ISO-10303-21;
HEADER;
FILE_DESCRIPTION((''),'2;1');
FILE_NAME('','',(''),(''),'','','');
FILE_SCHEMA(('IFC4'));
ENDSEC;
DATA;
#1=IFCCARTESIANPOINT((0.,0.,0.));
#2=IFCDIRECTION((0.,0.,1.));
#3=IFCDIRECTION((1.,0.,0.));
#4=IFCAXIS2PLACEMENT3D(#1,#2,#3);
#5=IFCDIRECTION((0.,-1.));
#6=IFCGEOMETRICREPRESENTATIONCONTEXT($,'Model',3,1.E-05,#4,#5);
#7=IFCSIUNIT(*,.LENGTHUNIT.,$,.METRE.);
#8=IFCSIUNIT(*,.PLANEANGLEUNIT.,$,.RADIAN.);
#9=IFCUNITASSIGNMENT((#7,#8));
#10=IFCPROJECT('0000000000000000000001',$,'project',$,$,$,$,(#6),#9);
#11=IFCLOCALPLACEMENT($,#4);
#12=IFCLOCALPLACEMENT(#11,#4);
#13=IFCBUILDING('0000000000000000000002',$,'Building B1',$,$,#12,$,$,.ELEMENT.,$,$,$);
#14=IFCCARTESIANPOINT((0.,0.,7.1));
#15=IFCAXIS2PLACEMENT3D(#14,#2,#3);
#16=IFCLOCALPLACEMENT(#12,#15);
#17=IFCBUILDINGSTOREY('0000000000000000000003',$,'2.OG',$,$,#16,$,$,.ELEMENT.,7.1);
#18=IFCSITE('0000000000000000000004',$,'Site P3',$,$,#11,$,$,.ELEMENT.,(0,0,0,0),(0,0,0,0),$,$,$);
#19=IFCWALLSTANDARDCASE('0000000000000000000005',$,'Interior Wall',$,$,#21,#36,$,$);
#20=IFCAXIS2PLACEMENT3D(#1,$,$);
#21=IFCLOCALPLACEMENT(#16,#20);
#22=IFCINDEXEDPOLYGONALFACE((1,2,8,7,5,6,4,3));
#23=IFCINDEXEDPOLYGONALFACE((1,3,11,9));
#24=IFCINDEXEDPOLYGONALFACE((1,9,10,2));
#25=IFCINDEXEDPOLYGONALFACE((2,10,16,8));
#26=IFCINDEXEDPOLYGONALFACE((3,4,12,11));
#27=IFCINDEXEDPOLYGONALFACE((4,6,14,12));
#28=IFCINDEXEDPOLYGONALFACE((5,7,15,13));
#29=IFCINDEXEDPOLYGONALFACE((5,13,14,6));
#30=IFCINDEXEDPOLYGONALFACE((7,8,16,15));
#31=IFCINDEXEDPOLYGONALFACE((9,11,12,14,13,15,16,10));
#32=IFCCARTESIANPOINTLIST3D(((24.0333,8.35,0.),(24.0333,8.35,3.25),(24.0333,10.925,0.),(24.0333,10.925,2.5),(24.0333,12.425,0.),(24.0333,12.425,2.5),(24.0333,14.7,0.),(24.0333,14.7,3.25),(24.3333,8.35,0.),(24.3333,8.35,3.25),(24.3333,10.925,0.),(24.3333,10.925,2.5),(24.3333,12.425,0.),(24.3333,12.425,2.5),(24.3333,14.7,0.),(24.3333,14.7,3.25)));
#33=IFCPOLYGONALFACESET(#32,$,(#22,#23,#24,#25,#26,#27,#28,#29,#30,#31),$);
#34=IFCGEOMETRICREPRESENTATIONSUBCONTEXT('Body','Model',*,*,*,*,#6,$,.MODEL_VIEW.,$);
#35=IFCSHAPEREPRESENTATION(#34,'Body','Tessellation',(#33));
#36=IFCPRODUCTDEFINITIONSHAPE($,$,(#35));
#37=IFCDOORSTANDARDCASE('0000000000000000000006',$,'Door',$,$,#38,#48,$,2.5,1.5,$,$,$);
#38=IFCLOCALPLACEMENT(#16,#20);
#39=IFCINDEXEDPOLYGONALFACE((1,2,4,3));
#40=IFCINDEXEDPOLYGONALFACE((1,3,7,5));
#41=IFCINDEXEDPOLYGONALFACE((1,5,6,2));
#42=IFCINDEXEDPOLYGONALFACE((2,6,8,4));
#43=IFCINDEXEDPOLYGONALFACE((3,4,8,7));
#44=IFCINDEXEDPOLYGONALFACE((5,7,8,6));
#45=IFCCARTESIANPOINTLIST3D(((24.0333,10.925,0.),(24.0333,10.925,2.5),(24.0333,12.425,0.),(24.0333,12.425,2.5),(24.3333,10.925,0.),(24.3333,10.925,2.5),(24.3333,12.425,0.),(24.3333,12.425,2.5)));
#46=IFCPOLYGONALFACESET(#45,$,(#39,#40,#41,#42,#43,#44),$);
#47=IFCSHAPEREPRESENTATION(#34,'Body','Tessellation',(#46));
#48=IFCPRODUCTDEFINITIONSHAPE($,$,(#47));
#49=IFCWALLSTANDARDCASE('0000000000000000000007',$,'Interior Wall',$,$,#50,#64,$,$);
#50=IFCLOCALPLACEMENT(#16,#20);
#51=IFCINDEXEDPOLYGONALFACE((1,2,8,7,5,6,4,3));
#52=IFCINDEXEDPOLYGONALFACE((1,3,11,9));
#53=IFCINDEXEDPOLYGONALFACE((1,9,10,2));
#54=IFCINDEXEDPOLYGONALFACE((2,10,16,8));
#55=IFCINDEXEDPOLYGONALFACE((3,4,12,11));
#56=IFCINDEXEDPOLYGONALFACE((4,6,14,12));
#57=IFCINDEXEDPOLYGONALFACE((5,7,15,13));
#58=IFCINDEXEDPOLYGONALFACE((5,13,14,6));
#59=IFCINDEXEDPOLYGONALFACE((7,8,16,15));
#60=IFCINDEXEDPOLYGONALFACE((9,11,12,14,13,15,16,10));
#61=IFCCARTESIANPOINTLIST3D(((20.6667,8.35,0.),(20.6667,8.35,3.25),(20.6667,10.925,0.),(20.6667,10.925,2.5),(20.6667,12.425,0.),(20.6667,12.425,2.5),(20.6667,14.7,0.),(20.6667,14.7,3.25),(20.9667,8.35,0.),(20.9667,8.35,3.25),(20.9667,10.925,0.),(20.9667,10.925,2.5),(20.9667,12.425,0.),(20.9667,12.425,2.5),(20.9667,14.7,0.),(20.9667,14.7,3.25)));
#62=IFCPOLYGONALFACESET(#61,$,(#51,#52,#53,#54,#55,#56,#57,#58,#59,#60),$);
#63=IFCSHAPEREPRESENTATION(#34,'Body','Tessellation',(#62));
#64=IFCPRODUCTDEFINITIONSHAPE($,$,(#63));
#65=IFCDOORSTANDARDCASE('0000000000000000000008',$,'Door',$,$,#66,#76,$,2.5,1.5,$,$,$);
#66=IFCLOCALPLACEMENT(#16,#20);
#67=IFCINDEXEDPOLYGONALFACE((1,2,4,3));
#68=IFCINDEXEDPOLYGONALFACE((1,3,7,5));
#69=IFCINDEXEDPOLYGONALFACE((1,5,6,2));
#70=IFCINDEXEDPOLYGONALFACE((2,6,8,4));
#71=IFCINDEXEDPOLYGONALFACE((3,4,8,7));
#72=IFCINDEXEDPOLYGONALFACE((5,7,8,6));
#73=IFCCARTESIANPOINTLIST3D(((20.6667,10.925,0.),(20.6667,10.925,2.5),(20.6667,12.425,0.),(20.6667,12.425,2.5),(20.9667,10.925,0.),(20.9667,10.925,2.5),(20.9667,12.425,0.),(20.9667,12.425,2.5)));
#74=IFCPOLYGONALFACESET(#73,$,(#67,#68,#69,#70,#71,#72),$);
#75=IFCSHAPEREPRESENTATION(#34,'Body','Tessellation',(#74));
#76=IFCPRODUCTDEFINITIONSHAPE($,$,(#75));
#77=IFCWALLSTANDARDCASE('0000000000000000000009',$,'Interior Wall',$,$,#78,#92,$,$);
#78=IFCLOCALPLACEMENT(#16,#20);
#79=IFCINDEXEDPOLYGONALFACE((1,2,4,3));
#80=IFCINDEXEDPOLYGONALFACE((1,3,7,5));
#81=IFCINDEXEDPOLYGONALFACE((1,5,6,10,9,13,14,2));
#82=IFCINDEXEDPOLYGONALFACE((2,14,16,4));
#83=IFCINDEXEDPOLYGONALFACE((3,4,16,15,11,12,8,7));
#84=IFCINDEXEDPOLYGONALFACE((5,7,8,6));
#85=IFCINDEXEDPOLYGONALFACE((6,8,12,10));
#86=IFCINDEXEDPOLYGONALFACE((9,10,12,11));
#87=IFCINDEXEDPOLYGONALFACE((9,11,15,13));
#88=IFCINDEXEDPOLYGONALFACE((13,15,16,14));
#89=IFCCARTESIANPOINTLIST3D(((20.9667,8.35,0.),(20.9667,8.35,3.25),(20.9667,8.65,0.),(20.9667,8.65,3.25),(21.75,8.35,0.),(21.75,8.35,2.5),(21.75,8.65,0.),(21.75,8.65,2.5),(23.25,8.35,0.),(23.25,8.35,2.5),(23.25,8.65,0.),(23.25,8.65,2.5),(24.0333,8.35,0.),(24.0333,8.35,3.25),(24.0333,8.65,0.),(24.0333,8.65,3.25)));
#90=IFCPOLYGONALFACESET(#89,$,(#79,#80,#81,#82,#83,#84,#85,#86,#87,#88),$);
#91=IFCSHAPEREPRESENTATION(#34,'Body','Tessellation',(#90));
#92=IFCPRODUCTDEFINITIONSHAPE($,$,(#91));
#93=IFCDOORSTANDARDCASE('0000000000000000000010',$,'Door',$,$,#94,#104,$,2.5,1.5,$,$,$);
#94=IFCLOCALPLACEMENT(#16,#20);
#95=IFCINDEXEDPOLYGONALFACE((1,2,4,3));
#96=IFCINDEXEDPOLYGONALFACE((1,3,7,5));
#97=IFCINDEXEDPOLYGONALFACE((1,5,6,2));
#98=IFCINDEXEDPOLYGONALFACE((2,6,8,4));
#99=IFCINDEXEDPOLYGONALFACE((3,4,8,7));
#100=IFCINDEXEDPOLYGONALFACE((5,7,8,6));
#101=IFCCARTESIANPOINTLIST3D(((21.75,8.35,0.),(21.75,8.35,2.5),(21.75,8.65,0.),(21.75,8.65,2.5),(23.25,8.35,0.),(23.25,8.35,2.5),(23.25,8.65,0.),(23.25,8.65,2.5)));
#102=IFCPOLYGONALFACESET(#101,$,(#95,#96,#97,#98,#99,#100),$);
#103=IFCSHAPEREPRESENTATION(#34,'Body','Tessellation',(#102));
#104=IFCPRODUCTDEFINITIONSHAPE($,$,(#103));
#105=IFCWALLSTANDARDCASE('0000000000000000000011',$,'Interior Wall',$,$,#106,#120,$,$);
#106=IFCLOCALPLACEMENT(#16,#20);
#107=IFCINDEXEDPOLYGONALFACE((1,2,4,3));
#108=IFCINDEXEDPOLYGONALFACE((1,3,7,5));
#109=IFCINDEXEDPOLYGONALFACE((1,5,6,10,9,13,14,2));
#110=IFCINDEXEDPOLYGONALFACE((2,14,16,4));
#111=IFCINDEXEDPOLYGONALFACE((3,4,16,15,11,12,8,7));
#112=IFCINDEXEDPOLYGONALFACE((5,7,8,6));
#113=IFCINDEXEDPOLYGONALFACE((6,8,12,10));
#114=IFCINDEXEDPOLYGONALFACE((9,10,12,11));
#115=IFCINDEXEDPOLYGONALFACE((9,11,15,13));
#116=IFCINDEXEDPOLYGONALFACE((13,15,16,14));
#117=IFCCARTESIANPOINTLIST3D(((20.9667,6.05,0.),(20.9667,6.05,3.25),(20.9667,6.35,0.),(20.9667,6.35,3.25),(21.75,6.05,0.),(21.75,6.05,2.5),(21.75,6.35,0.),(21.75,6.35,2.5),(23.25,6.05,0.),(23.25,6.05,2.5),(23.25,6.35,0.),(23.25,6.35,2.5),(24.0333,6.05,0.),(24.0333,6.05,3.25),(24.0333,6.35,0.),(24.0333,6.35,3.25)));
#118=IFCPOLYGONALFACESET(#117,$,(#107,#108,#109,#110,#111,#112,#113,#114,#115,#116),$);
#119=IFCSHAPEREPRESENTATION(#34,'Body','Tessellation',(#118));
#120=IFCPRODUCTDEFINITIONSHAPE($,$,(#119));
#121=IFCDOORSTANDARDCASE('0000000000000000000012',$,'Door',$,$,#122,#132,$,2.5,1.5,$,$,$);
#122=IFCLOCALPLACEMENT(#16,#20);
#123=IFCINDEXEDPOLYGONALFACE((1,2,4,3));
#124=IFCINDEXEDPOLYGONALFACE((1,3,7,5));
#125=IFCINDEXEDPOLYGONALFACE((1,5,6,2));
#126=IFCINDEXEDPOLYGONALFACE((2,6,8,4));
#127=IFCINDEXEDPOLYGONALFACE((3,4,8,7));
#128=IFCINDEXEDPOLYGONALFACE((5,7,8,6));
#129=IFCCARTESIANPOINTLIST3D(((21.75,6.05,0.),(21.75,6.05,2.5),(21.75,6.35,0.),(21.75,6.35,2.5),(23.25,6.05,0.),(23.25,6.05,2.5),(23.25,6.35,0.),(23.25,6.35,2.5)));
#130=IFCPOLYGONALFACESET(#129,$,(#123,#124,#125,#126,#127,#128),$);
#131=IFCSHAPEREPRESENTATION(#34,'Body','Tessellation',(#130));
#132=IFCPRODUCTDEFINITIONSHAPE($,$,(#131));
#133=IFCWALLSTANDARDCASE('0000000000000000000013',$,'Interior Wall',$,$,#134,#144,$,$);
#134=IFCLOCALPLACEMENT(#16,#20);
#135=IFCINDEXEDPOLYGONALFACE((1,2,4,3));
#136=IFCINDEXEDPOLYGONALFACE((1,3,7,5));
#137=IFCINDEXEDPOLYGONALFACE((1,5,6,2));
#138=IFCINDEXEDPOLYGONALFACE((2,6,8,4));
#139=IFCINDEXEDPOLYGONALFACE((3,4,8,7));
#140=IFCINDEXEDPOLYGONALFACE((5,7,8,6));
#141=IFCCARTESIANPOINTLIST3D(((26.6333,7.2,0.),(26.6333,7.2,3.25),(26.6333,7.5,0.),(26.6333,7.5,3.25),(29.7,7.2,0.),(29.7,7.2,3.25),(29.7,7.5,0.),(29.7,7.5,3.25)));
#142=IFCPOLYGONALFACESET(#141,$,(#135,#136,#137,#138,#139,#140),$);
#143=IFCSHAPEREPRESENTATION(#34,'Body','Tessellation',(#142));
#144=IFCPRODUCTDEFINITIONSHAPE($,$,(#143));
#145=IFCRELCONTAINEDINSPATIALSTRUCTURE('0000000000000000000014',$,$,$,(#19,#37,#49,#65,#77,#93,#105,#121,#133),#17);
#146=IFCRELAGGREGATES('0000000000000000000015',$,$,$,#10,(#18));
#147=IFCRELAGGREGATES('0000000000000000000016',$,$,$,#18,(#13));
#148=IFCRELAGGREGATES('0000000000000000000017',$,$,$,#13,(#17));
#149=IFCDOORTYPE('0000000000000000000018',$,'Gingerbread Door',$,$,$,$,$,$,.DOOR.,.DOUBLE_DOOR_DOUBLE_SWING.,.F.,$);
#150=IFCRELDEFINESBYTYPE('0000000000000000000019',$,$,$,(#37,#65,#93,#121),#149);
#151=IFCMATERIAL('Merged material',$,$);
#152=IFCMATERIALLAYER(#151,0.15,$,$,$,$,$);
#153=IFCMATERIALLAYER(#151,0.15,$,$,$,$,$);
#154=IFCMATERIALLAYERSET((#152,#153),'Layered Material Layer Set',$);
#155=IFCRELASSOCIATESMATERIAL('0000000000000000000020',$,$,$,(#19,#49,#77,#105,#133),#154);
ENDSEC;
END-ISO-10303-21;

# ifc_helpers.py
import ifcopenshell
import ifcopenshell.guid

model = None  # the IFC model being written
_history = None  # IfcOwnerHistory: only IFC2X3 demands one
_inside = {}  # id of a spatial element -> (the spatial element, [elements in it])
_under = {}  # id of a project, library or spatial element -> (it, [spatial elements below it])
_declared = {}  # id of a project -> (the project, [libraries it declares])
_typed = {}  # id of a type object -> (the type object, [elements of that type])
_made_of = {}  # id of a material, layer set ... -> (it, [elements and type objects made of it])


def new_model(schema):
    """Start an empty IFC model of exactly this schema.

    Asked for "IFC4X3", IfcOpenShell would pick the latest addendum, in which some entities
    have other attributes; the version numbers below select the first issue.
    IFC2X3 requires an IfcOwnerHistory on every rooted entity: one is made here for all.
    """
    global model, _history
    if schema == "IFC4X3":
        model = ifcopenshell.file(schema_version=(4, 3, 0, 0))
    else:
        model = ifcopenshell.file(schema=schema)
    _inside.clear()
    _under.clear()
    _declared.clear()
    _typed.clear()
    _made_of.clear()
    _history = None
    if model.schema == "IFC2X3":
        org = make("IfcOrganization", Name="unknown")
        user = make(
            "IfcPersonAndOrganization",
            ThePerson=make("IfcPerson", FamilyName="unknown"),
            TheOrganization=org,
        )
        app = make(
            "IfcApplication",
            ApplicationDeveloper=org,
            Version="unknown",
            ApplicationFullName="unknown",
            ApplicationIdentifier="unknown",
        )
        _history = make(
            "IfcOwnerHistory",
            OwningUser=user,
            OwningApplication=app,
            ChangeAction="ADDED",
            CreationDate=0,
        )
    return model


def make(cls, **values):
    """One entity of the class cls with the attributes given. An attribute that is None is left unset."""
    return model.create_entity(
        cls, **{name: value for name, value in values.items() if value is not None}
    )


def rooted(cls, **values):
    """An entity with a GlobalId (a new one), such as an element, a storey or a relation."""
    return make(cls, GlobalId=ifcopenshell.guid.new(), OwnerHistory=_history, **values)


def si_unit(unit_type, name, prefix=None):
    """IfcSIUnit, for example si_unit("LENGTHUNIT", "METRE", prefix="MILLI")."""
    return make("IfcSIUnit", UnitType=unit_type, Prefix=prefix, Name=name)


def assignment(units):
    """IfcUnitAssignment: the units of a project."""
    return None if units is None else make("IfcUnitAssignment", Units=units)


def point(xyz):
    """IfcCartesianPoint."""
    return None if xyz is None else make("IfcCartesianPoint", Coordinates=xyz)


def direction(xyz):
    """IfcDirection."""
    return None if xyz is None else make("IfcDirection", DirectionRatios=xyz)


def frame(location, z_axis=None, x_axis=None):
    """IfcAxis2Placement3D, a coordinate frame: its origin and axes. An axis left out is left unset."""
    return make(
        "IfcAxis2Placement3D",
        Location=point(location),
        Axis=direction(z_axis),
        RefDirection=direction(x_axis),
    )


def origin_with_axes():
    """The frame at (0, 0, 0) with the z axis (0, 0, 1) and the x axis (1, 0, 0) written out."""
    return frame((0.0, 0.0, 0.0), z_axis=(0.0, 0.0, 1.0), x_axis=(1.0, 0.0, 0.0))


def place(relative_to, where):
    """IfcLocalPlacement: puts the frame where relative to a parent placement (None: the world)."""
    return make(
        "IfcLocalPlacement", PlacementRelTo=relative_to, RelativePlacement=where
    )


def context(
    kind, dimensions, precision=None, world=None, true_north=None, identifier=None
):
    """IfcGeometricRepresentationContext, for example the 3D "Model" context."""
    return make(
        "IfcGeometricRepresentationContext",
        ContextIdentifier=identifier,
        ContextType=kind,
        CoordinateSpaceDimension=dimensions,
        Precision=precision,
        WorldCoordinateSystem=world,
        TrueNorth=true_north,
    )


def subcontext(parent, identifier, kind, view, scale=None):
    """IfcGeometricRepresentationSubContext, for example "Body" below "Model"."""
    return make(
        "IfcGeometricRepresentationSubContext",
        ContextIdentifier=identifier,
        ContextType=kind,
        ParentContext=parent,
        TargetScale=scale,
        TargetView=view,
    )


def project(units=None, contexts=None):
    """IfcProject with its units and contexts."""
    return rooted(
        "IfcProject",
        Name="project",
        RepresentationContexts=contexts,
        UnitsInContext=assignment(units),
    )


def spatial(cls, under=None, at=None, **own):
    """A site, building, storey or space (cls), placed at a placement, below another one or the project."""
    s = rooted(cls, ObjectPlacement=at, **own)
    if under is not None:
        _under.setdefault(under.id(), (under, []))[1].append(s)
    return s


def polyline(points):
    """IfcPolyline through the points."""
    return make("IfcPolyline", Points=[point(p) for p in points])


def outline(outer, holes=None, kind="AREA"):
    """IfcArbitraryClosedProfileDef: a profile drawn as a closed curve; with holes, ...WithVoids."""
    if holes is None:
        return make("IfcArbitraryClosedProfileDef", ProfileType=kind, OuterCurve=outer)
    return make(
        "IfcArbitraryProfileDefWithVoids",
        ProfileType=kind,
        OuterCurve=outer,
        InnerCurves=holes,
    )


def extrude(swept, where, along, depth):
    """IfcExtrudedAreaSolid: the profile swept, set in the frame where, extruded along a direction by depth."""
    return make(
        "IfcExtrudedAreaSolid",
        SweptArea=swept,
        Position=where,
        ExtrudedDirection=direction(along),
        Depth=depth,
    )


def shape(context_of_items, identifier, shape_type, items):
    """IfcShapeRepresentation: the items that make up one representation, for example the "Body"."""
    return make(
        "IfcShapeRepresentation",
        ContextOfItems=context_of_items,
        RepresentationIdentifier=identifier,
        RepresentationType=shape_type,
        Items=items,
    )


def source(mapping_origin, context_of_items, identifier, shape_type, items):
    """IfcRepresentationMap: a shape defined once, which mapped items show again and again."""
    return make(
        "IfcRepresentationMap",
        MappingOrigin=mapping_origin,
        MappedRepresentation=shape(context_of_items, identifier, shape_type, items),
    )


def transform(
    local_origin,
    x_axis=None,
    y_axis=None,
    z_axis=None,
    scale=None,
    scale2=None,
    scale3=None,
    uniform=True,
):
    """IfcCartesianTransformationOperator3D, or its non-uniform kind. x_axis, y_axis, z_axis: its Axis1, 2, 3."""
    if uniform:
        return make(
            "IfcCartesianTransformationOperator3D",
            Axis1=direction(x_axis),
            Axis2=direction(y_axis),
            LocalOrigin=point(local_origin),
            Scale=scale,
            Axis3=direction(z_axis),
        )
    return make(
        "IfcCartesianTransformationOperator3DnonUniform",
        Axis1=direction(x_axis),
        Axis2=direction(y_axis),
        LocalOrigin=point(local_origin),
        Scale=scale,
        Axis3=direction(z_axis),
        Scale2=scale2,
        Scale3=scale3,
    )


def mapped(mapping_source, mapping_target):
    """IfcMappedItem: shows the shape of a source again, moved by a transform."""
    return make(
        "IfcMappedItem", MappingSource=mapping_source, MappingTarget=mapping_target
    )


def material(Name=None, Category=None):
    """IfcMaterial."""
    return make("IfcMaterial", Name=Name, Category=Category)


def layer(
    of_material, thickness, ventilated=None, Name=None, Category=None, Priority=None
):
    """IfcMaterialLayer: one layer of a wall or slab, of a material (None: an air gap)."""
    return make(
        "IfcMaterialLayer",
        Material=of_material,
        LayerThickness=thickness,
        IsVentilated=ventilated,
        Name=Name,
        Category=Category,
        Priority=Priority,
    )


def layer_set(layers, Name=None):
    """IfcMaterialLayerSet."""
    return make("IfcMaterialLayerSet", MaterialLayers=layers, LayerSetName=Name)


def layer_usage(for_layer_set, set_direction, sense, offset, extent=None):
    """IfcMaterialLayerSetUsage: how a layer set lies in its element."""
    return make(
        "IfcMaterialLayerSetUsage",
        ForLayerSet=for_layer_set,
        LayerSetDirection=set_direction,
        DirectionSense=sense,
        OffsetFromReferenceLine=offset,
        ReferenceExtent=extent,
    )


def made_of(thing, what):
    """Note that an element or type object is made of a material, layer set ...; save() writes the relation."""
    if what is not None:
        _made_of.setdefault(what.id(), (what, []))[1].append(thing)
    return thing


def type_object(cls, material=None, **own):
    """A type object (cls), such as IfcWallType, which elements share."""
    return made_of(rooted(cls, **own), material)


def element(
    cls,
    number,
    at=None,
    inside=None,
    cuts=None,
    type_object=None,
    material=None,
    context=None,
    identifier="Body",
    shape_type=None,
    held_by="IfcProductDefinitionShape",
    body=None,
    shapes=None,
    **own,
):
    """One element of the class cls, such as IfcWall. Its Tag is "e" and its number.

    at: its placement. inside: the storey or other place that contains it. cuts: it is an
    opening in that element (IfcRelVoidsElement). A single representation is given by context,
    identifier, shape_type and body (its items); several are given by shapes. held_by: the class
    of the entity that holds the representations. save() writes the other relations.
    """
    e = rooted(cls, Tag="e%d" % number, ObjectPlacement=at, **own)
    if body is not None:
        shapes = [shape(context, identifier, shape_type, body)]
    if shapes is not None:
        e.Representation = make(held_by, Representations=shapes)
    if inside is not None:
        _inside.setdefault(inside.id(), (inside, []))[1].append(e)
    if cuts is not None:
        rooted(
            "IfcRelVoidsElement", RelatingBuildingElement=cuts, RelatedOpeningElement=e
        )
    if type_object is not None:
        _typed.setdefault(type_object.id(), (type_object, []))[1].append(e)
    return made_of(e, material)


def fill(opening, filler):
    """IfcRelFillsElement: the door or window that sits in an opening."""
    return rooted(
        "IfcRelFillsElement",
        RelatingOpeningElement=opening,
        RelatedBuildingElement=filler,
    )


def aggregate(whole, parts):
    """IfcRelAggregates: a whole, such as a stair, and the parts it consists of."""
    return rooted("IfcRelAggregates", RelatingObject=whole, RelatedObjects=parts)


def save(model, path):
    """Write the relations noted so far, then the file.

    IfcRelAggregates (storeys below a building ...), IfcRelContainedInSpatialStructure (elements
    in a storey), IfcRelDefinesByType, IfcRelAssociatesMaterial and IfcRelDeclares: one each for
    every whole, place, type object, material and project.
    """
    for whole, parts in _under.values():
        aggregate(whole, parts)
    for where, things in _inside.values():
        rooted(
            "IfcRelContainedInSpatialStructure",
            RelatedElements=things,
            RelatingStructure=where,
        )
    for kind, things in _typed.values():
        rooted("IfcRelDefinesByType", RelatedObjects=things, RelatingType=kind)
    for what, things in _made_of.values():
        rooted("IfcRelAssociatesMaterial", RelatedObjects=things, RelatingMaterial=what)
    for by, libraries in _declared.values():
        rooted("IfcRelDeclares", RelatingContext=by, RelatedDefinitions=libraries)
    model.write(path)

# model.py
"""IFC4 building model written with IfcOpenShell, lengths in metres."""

from ifc_helpers import new_model, si_unit, direction, frame, origin_with_axes, place, context, subcontext, project, spatial, polyline, outline, extrude, source, transform, mapped, material, layer, layer_set, layer_usage, type_object, element, fill, save


model = new_model("IFC4")

# Units and contexts
model_context = context("Model", 3, precision=1e-05, world=origin_with_axes(), true_north=direction((0.0, -1.0)))
body_context = subcontext(model_context, "Body", "Model", "MODEL_VIEW")
ifc_project = project(units=[si_unit("LENGTHUNIT", "METRE"), si_unit("PLANEANGLEUNIT", "RADIAN")], contexts=[model_context])

# Site, building, storey
site_placement = place(None, origin_with_axes())
site = spatial("IfcSite", under=ifc_project, at=site_placement, Name="Site P3", CompositionType="ELEMENT", RefLatitude=(0, 0, 0, 0), RefLongitude=(0, 0, 0, 0))
building_placement = place(site_placement, origin_with_axes())
building = spatial("IfcBuilding", under=site, at=building_placement, Name="Building B1", CompositionType="ELEMENT")
storey_placement = place(building_placement, frame((0.0, 0.0, 7.1), z_axis=(0.0, 0.0, 1.0), x_axis=(1.0, 0.0, 0.0)))
storey = spatial("IfcBuildingStorey", under=building, at=storey_placement, Name="2.OG", CompositionType="ELEMENT", Elevation=7.1)

# Shared definitions
ifc_material = material(Name="Merged material")

# Shared definitions
ifc_layer_1 = layer(ifc_material, 0.15)
ifc_layer_2 = layer(ifc_material, 0.15)
ifc_layer_set_1 = layer_set([ifc_layer_1, ifc_layer_2], Name="Layered Material Layer Set")
ifc_layer_usage_1 = layer_usage(ifc_layer_set_1, "AXIS2", "POSITIVE", -0.15)
door_type = type_object("IfcDoorType", Name="Gingerbread Door", OperationType="DOUBLE_DOOR_DOUBLE_SWING", ParameterTakesPrecedence=False, PredefinedType="DOOR")
shared_shape_1 = source(origin_with_axes(), body_context, "Body", "SweptSolid", [
    extrude(outline(polyline([(0.0, 0.0), (0.0, 1.5), (2.5, 1.5), (2.5, 0.0), (0.0, 0.0)])), frame((0.0, -0.15, 0.0), z_axis=(0.0, 1.0, 0.0), x_axis=(0.0, 0.0, 1.0)), (0.0, 0.0, 1.0), 0.3),
])

# Walls, openings, doors
wall_1_placement = place(storey_placement, frame((24.1833, 14.7, 0.0), z_axis=(0.0, 0.0, 1.0), x_axis=(0.0, -1.0, 0.0)))
wall_1 = element("IfcWallStandardCase", 1, at=wall_1_placement, inside=storey, material=ifc_layer_usage_1, Name="Interior Wall", context=body_context, shape_type="SweptSolid", body=[
    extrude(outline(polyline([(0.0, 0.15), (6.35, 0.15), (6.35, -0.15), (0.0, -0.15), (0.0, 0.15)])), origin_with_axes(), (0.0, 0.0, 1.0), 3.25),
])
opening_1_placement = place(wall_1_placement, frame((2.275, 0.0, 0.0), z_axis=(0.0, 0.0, 1.0), x_axis=(1.0, 0.0, 0.0)))
opening_1 = element("IfcOpeningStandardCase", 2, at=opening_1_placement, cuts=wall_1, context=body_context, shape_type="SweptSolid", body=[
    extrude(outline(polyline([(0.0, 0.0), (0.0, 1.5), (2.5, 1.5), (2.5, 0.0), (0.0, 0.0)])), frame((0.0, -0.15, 0.0), z_axis=(0.0, 1.0, 0.0), x_axis=(0.0, 0.0, 1.0)), (0.0, 0.0, 1.0), 0.3),
])
door_1_placement = place(opening_1_placement, origin_with_axes())
door_1 = element("IfcDoorStandardCase", 3, at=door_1_placement, inside=storey, type_object=door_type, Name="Door", OverallHeight=2.5, OverallWidth=1.5, context=body_context, shape_type="MappedRepresentation", body=[
    mapped(shared_shape_1, transform((0.0, 0.0, 0.0))),
])
fill(opening_1, door_1)
wall_2_placement = place(storey_placement, frame((20.8167, 14.7, 0.0), z_axis=(0.0, 0.0, 1.0), x_axis=(0.0, -1.0, 0.0)))
wall_2 = element("IfcWallStandardCase", 4, at=wall_2_placement, inside=storey, material=ifc_layer_usage_1, Name="Interior Wall", context=body_context, shape_type="SweptSolid", body=[
    extrude(outline(polyline([(0.0, 0.15), (6.35, 0.15), (6.35, -0.15), (0.0, -0.15), (0.0, 0.15)])), origin_with_axes(), (0.0, 0.0, 1.0), 3.25),
])
opening_2_placement = place(wall_2_placement, frame((2.275, 0.0, 0.0), z_axis=(0.0, 0.0, 1.0), x_axis=(1.0, 0.0, 0.0)))
opening_2 = element("IfcOpeningStandardCase", 5, at=opening_2_placement, cuts=wall_2, context=body_context, shape_type="SweptSolid", body=[
    extrude(outline(polyline([(0.0, 0.0), (0.0, 1.5), (2.5, 1.5), (2.5, 0.0), (0.0, 0.0)])), frame((0.0, -0.15, 0.0), z_axis=(0.0, 1.0, 0.0), x_axis=(0.0, 0.0, 1.0)), (0.0, 0.0, 1.0), 0.3),
])
door_2_placement = place(opening_2_placement, origin_with_axes())
door_2 = element("IfcDoorStandardCase", 6, at=door_2_placement, inside=storey, type_object=door_type, Name="Door", OverallHeight=2.5, OverallWidth=1.5, context=body_context, shape_type="MappedRepresentation", body=[
    mapped(shared_shape_1, transform((0.0, 0.0, 0.0))),
])
fill(opening_2, door_2)
wall_3_placement = place(storey_placement, frame((20.9667, 8.5, 0.0), z_axis=(0.0, 0.0, 1.0), x_axis=(1.0, 0.0, 0.0)))
wall_3 = element("IfcWallStandardCase", 7, at=wall_3_placement, inside=storey, material=ifc_layer_usage_1, Name="Interior Wall", context=body_context, shape_type="SweptSolid", body=[
    extrude(outline(polyline([(0.0, 0.15), (3.0667, 0.15), (3.0667, -0.15), (0.0, -0.15), (0.0, 0.15)])), origin_with_axes(), (0.0, 0.0, 1.0), 3.25),
])
opening_3_placement = place(wall_3_placement, frame((0.7833, 0.0, 0.0), z_axis=(0.0, 0.0, 1.0), x_axis=(1.0, 0.0, 0.0)))
opening_3 = element("IfcOpeningStandardCase", 8, at=opening_3_placement, cuts=wall_3, context=body_context, shape_type="SweptSolid", body=[
    extrude(outline(polyline([(0.0, 0.0), (0.0, 1.5), (2.5, 1.5), (2.5, 0.0), (0.0, 0.0)])), frame((0.0, -0.15, 0.0), z_axis=(0.0, 1.0, 0.0), x_axis=(0.0, 0.0, 1.0)), (0.0, 0.0, 1.0), 0.3),
])
door_3_placement = place(opening_3_placement, origin_with_axes())
door_3 = element("IfcDoorStandardCase", 9, at=door_3_placement, inside=storey, type_object=door_type, Name="Door", OverallHeight=2.5, OverallWidth=1.5, context=body_context, shape_type="MappedRepresentation", body=[
    mapped(shared_shape_1, transform((0.0, 0.0, 0.0))),
])
fill(opening_3, door_3)
wall_4_placement = place(storey_placement, frame((20.9667, 6.2, 0.0), z_axis=(0.0, 0.0, 1.0), x_axis=(1.0, 0.0, 0.0)))
wall_4 = element("IfcWallStandardCase", 10, at=wall_4_placement, inside=storey, material=ifc_layer_usage_1, Name="Interior Wall", context=body_context, shape_type="SweptSolid", body=[
    extrude(outline(polyline([(0.0, 0.15), (3.0667, 0.15), (3.0667, -0.15), (0.0, -0.15), (0.0, 0.15)])), origin_with_axes(), (0.0, 0.0, 1.0), 3.25),
])
opening_4_placement = place(wall_4_placement, frame((0.7833, 0.0, 0.0), z_axis=(0.0, 0.0, 1.0), x_axis=(1.0, 0.0, 0.0)))
opening_4 = element("IfcOpeningStandardCase", 11, at=opening_4_placement, cuts=wall_4, context=body_context, shape_type="SweptSolid", body=[
    extrude(outline(polyline([(0.0, 0.0), (0.0, 1.5), (2.5, 1.5), (2.5, 0.0), (0.0, 0.0)])), frame((0.0, -0.15, 0.0), z_axis=(0.0, 1.0, 0.0), x_axis=(0.0, 0.0, 1.0)), (0.0, 0.0, 1.0), 0.3),
])
door_4_placement = place(opening_4_placement, origin_with_axes())
door_4 = element("IfcDoorStandardCase", 12, at=door_4_placement, inside=storey, type_object=door_type, Name="Door", OverallHeight=2.5, OverallWidth=1.5, context=body_context, shape_type="MappedRepresentation", body=[
    mapped(shared_shape_1, transform((0.0, 0.0, 0.0))),
])
fill(opening_4, door_4)

# Wall
wall_5_placement = place(storey_placement, frame((26.6333, 7.35, 0.0), z_axis=(0.0, 0.0, 1.0), x_axis=(1.0, 0.0, 0.0)))
element("IfcWallStandardCase", 13, at=wall_5_placement, inside=storey, material=ifc_layer_usage_1, Name="Interior Wall", context=body_context, shape_type="SweptSolid", body=[
    extrude(outline(polyline([(0.0, 0.15), (3.0667, 0.15), (3.0667, -0.15), (0.0, -0.15), (0.0, 0.15)])), origin_with_axes(), (0.0, 0.0, 1.0), 3.25),
])

save(model, "model.ifc")
